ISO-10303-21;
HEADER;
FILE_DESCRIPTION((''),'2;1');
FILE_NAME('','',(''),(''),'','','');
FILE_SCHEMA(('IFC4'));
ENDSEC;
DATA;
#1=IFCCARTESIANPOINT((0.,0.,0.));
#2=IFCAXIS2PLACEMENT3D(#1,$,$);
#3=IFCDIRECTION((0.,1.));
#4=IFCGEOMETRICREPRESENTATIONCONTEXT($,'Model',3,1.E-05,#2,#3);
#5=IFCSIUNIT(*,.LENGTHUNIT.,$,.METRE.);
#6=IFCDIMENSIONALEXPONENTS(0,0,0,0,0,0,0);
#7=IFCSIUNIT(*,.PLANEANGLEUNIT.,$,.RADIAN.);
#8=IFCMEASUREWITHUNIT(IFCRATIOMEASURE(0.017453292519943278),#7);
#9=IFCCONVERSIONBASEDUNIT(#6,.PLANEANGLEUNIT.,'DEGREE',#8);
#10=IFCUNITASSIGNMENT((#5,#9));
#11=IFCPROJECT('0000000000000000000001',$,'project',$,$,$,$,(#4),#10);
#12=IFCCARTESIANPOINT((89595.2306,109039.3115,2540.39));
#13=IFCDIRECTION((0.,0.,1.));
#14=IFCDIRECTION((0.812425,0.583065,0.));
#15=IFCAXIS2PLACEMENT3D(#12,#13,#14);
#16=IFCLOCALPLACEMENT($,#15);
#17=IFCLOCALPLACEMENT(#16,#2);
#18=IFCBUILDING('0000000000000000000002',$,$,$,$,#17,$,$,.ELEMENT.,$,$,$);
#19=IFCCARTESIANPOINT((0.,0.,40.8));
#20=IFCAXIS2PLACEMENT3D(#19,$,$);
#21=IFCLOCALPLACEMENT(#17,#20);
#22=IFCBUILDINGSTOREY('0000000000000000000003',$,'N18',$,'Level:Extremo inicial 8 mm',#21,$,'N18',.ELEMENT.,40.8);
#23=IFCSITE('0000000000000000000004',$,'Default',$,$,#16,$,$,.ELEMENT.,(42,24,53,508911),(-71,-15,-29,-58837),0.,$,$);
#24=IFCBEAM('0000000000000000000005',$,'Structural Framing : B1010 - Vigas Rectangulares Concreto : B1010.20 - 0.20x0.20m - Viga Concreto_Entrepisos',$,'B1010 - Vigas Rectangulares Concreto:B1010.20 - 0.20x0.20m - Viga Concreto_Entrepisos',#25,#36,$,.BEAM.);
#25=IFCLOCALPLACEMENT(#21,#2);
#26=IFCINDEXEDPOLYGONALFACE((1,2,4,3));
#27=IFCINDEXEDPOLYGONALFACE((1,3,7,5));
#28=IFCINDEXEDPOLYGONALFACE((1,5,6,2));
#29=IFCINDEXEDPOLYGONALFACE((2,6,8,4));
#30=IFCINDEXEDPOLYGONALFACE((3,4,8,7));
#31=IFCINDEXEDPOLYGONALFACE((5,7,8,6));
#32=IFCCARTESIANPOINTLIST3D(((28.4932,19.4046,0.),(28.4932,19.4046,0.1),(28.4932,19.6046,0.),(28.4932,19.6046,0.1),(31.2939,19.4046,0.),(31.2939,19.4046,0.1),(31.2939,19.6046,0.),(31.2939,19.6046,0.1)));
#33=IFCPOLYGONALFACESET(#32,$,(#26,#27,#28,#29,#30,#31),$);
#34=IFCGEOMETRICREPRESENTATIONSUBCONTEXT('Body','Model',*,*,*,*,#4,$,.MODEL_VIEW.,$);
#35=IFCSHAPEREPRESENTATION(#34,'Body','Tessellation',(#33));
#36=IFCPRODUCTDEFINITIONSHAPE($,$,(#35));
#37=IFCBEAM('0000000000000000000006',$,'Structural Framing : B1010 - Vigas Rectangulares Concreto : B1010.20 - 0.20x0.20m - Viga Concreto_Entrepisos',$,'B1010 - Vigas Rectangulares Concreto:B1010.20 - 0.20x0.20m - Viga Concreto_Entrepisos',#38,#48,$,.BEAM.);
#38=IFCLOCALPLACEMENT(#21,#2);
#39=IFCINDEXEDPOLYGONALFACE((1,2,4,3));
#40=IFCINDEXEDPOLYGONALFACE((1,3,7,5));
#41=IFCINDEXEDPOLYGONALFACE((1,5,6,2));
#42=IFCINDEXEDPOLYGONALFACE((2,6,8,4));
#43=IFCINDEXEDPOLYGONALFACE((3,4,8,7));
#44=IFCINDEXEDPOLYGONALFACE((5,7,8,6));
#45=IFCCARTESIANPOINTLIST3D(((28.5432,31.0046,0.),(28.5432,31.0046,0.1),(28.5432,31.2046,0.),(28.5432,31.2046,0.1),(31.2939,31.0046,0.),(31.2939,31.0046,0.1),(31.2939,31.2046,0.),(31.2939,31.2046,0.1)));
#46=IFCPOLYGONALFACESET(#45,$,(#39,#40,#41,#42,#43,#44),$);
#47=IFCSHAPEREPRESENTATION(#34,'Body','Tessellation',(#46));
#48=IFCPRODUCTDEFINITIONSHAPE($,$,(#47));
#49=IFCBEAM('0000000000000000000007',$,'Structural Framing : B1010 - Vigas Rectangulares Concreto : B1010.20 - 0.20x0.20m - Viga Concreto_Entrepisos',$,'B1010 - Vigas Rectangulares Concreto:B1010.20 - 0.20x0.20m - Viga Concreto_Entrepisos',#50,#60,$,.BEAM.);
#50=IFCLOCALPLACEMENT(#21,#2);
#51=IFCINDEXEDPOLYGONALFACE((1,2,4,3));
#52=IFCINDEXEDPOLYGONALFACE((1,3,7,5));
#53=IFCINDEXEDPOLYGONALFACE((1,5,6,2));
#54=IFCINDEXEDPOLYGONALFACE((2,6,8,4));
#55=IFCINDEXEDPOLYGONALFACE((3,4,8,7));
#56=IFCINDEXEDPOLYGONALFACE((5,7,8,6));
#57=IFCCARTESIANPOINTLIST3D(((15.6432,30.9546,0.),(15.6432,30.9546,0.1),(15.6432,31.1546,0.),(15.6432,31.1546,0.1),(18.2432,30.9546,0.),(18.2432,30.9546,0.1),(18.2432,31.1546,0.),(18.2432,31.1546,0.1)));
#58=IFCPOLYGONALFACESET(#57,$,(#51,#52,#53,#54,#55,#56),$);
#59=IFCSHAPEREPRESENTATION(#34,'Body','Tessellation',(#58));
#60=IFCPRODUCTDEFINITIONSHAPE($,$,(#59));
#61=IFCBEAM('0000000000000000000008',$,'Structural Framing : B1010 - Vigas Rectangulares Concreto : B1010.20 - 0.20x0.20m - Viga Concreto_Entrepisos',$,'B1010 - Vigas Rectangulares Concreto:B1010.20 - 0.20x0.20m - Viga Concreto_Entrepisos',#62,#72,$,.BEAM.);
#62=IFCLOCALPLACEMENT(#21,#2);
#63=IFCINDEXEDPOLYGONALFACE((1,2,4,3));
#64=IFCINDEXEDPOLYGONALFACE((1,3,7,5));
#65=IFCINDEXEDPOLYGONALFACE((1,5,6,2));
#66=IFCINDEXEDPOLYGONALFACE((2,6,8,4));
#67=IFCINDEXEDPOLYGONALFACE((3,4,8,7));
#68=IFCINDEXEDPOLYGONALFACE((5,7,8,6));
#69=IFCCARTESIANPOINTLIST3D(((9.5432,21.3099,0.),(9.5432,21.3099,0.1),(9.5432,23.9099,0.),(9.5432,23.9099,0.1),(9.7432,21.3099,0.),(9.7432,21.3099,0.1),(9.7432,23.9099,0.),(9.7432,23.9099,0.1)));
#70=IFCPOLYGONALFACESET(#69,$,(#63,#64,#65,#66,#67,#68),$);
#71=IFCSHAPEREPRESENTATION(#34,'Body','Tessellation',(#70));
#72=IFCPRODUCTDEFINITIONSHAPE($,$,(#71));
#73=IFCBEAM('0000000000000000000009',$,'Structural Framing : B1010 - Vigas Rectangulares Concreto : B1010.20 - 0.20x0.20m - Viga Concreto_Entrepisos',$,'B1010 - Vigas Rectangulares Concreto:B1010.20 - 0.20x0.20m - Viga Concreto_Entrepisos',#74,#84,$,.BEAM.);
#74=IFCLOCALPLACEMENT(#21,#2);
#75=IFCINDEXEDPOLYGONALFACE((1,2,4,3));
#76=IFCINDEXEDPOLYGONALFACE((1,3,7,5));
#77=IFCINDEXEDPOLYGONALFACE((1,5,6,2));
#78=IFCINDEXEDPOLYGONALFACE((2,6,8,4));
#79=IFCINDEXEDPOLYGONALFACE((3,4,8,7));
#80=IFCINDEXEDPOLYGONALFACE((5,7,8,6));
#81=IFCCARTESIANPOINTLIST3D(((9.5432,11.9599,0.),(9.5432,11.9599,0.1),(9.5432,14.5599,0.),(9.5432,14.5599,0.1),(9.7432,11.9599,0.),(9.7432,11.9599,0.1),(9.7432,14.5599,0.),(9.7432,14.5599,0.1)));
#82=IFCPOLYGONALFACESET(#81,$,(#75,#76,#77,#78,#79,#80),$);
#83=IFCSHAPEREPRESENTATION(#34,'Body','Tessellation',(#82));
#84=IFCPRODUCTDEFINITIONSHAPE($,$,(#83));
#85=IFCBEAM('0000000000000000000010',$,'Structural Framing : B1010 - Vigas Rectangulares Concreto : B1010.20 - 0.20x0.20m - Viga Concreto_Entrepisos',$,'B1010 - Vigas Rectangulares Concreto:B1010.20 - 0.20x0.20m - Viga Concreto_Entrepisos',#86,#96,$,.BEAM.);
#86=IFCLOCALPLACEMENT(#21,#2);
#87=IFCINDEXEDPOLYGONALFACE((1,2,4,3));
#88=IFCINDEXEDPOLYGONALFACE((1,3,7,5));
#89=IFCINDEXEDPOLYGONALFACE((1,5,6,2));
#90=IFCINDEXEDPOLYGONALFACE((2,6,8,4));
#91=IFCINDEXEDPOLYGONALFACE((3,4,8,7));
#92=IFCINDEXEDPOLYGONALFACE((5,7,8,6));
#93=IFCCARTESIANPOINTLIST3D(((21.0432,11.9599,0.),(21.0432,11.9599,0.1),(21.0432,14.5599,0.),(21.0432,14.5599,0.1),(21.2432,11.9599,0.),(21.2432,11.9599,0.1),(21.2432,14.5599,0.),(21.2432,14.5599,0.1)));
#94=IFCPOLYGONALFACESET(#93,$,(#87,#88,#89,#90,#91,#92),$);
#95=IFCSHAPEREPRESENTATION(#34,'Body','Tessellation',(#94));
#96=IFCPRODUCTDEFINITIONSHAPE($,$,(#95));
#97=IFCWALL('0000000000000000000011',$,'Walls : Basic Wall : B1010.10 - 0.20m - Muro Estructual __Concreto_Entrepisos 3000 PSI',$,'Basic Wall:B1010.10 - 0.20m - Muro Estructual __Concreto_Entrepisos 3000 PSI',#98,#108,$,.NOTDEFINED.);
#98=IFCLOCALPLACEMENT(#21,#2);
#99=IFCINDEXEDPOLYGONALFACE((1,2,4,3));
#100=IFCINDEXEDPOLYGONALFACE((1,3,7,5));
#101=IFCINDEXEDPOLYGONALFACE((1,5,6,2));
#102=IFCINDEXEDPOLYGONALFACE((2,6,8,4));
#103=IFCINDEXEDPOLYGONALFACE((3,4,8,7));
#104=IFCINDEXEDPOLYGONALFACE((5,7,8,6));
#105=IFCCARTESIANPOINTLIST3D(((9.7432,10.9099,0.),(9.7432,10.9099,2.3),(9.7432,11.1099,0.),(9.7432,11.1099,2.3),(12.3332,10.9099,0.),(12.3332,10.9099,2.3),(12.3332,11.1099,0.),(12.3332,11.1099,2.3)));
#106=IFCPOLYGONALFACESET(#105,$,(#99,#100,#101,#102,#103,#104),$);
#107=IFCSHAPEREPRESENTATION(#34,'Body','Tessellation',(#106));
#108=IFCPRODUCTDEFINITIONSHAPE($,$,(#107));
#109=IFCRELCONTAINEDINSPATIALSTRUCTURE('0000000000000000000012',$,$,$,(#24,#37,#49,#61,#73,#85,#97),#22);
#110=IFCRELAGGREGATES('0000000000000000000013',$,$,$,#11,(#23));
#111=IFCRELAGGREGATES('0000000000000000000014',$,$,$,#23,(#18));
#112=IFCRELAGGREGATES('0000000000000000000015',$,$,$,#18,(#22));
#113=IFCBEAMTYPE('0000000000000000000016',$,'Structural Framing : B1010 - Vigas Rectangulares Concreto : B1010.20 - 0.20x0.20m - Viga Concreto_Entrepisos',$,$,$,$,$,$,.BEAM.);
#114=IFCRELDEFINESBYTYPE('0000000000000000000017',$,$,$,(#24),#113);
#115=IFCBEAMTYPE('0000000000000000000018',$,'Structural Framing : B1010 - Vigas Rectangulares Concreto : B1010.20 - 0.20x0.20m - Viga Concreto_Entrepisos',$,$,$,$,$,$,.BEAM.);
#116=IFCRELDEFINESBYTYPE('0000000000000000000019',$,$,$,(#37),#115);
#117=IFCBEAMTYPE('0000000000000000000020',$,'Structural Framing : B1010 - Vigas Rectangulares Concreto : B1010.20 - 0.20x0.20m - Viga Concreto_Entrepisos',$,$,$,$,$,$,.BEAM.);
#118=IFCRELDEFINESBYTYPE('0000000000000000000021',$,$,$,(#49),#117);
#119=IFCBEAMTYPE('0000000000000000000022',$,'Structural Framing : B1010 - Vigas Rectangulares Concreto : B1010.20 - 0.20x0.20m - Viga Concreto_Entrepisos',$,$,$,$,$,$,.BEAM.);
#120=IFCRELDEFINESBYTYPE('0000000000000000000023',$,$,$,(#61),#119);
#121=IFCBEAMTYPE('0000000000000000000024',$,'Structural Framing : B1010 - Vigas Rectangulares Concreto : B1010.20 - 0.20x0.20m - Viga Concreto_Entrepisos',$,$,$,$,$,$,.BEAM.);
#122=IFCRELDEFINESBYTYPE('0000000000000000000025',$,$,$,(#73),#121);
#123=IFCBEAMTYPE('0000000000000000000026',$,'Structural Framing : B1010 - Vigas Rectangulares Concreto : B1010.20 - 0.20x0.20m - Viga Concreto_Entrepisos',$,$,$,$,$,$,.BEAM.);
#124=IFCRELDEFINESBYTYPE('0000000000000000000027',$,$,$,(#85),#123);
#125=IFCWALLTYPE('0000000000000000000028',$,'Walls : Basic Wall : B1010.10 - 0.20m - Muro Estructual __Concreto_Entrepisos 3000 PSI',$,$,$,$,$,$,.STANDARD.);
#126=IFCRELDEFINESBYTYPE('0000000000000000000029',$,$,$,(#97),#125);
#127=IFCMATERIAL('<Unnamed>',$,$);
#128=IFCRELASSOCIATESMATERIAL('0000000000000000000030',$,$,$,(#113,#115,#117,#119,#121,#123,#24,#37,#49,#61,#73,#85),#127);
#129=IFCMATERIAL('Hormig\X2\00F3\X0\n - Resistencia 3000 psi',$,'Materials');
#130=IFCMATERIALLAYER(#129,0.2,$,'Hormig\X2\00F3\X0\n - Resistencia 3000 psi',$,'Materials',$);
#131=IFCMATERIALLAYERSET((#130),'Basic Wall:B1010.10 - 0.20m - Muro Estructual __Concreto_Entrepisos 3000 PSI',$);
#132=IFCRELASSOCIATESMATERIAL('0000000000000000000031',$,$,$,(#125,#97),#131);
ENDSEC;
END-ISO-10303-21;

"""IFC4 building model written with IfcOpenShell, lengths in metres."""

from ifc_helpers import new_model, entity, si_unit, converted_unit, direction, frame, frame_2d, origin, place, context, subcontext, project, spatial, polyline, segment, composite_curve, rectangle, outline, extrude, source, transform, mapped, material, layer, layer_set, layer_usage, material_profile, profile_set, profile_usage, type_object, type_shapes, element, save


model = new_model("IFC4")

# Units and contexts
model_context = context("Model", 3, precision=1e-05, world=origin(), true_north=direction((0.0, 1.0)))
body_context = subcontext(model_context, "Body", "Model", "MODEL_VIEW")
ifc_project = project(units=[si_unit("LENGTHUNIT", "METRE"), converted_unit("PLANEANGLEUNIT", "DEGREE", entity("IfcRatioMeasure", 0.017453292519943278), si_unit("PLANEANGLEUNIT", "RADIAN"), dimensions=[0, 0, 0, 0, 0, 0, 0])], contexts=[model_context])

# Site, building, storey
site_placement = place(None, frame((89595.2306, 109039.3115, 2540.39), z_axis=(0.0, 0.0, 1.0), x_axis=(0.812425, 0.583065, 0.0)))
site = spatial("IfcSite", under=ifc_project, at=site_placement, Name="Default", CompositionType="ELEMENT", RefLatitude=(42, 24, 53, 508911), RefLongitude=(-71, -15, -29, -58837), RefElevation=0.0)
building_placement = place(site_placement, origin())
building = spatial("IfcBuilding", under=site, at=building_placement, CompositionType="ELEMENT")
storey_placement = place(building_placement, frame((0.0, 0.0, 40.8)))
storey = spatial("IfcBuildingStorey", under=building, at=storey_placement, Name="N18", ObjectType="Level:Extremo inicial 8 mm", LongName="N18", CompositionType="ELEMENT", Elevation=40.8)

# Beams
ifc_material_1 = material(Name="<Unnamed>")
ifc_material_profile_1 = material_profile(ifc_material_1, outline(composite_curve([segment(polyline([(-0.1, 0.0, 0.0), (-0.1, 0.1, 0.0)]), True, "CONTINUOUS"), segment(polyline([(-0.1, 0.1, 0.0), (0.1, 0.1, 0.0)]), True, "CONTINUOUS"), segment(polyline([(0.1, 0.1, 0.0), (0.1, 0.0, 0.0)]), True, "CONTINUOUS"), segment(polyline([(0.1, 0.0, 0.0), (-0.1, 0.0, 0.0)]), True, "CONTINUOUS")], self_intersect=False), kind="CURVE"), Name="B1010.20 - 0.20x0.20m - Viga Concreto_Entrepisos")
ifc_material_profile_2 = material_profile(ifc_material_1, outline(composite_curve([segment(polyline([(-1.4004, -0.1, 0.1), (-1.4004, 0.1, 0.1)]), True, "CONTINUOUS"), segment(polyline([(-1.4004, 0.1, 0.1), (-1.4004, 0.1, -0.1)]), True, "CONTINUOUS"), segment(polyline([(-1.4004, 0.1, -0.1), (-1.4004, -0.1, -0.1)]), True, "CONTINUOUS"), segment(polyline([(-1.4004, -0.1, -0.1), (-1.4004, -0.1, 0.1)]), True, "CONTINUOUS")], self_intersect=False), kind="CURVE"), Name="B1010.20 - 0.20x0.20m - Viga Concreto_Entrepisos")
ifc_profile_set_1 = profile_set([ifc_material_profile_1, ifc_material_profile_2], Name="B1010.20 - 0.20x0.20m - Viga Concreto_Entrepisos")
ifc_profile_usage_1 = profile_usage(ifc_profile_set_1, cardinal=8)
beam_type_1 = type_object("IfcBeamType", Name="Structural Framing : B1010 - Vigas Rectangulares Concreto : B1010.20 - 0.20x0.20m - Viga Concreto_Entrepisos", PredefinedType="BEAM", material=ifc_profile_set_1)
shared_shape_1 = source(origin(), body_context, "Body", "SweptSolid", [
    extrude(rectangle(XDim=0.1, YDim=0.2, at=frame_2d((0.0, 0.0), x_axis=(1.0, 0.0))), frame((31.2939, 19.5046, 40.85), z_axis=(-1.0, 0.0, 0.0), x_axis=(0.0, 0.0, -1.0)), (0.0, 0.0, 1.0), 2.8007),
])
type_shapes(beam_type_1, [shared_shape_1])
beam_1_placement = place(storey_placement, frame((0.0, 0.0, -40.8)))
element("IfcBeam", 1, at=beam_1_placement, inside=storey, type_object=beam_type_1, material=ifc_profile_usage_1, Name="Structural Framing : B1010 - Vigas Rectangulares Concreto : B1010.20 - 0.20x0.20m - Viga Concreto_Entrepisos", ObjectType="B1010 - Vigas Rectangulares Concreto:B1010.20 - 0.20x0.20m - Viga Concreto_Entrepisos", PredefinedType="BEAM", context=body_context, shape_type="MappedRepresentation", body=[
    mapped(shared_shape_1, transform((0.0, 0.0, 0.0), scale=1.0)),
])
ifc_profile_usage_2 = profile_usage(ifc_profile_set_1, cardinal=8)
beam_type_2 = type_object("IfcBeamType", Name="Structural Framing : B1010 - Vigas Rectangulares Concreto : B1010.20 - 0.20x0.20m - Viga Concreto_Entrepisos", PredefinedType="BEAM", material=ifc_profile_set_1)
shared_shape_2 = source(origin(), body_context, "Body", "SweptSolid", [
    extrude(rectangle(XDim=0.1, YDim=0.2, at=frame_2d((0.0, 0.0), x_axis=(1.0, 0.0))), frame((31.2939, 31.1046, 40.85), z_axis=(-1.0, 0.0, 0.0), x_axis=(0.0, 0.0, -1.0)), (0.0, 0.0, 1.0), 2.7507),
])
type_shapes(beam_type_2, [shared_shape_2])
beam_2_placement = place(storey_placement, frame((0.0, 0.0, -40.8)))
element("IfcBeam", 2, at=beam_2_placement, inside=storey, type_object=beam_type_2, material=ifc_profile_usage_2, Name="Structural Framing : B1010 - Vigas Rectangulares Concreto : B1010.20 - 0.20x0.20m - Viga Concreto_Entrepisos", ObjectType="B1010 - Vigas Rectangulares Concreto:B1010.20 - 0.20x0.20m - Viga Concreto_Entrepisos", PredefinedType="BEAM", context=body_context, shape_type="MappedRepresentation", body=[
    mapped(shared_shape_2, transform((0.0, 0.0, 0.0), scale=1.0)),
])
ifc_profile_usage_3 = profile_usage(ifc_profile_set_1, cardinal=8)
beam_type_3 = type_object("IfcBeamType", Name="Structural Framing : B1010 - Vigas Rectangulares Concreto : B1010.20 - 0.20x0.20m - Viga Concreto_Entrepisos", PredefinedType="BEAM", material=ifc_profile_set_1)
shared_shape_3 = source(origin(), body_context, "Body", "SweptSolid", [
    extrude(rectangle(XDim=0.1, YDim=0.2, at=frame_2d((0.0, 0.0), x_axis=(1.0, 0.0))), frame((18.2432, 31.0546, 40.85), z_axis=(-1.0, 0.0, 0.0), x_axis=(0.0, 0.0, -1.0)), (0.0, 0.0, 1.0), 2.6),
])
type_shapes(beam_type_3, [shared_shape_3])
beam_3_placement = place(storey_placement, frame((0.0, 0.0, -40.8)))
element("IfcBeam", 3, at=beam_3_placement, inside=storey, type_object=beam_type_3, material=ifc_profile_usage_3, Name="Structural Framing : B1010 - Vigas Rectangulares Concreto : B1010.20 - 0.20x0.20m - Viga Concreto_Entrepisos", ObjectType="B1010 - Vigas Rectangulares Concreto:B1010.20 - 0.20x0.20m - Viga Concreto_Entrepisos", PredefinedType="BEAM", context=body_context, shape_type="MappedRepresentation", body=[
    mapped(shared_shape_3, transform((0.0, 0.0, 0.0), scale=1.0)),
])
ifc_profile_usage_4 = profile_usage(ifc_profile_set_1, cardinal=8)
beam_type_4 = type_object("IfcBeamType", Name="Structural Framing : B1010 - Vigas Rectangulares Concreto : B1010.20 - 0.20x0.20m - Viga Concreto_Entrepisos", PredefinedType="BEAM", material=ifc_profile_set_1)
shared_shape_4 = source(origin(), body_context, "Body", "SweptSolid", [
    extrude(rectangle(XDim=0.1, YDim=0.2, at=frame_2d((0.0, 0.0), x_axis=(0.0, 1.0))), frame((9.6432, 21.3099, 40.85), z_axis=(0.0, 1.0, 0.0), x_axis=(-1.0, 0.0, 0.0)), (0.0, 0.0, 1.0), 2.6),
])
type_shapes(beam_type_4, [shared_shape_4])
beam_4_placement = place(storey_placement, frame((0.0, 0.0, -40.8)))
element("IfcBeam", 4, at=beam_4_placement, inside=storey, type_object=beam_type_4, material=ifc_profile_usage_4, Name="Structural Framing : B1010 - Vigas Rectangulares Concreto : B1010.20 - 0.20x0.20m - Viga Concreto_Entrepisos", ObjectType="B1010 - Vigas Rectangulares Concreto:B1010.20 - 0.20x0.20m - Viga Concreto_Entrepisos", PredefinedType="BEAM", context=body_context, shape_type="MappedRepresentation", body=[
    mapped(shared_shape_4, transform((0.0, 0.0, 0.0), scale=1.0)),
])
ifc_profile_usage_5 = profile_usage(ifc_profile_set_1, cardinal=8)
beam_type_5 = type_object("IfcBeamType", Name="Structural Framing : B1010 - Vigas Rectangulares Concreto : B1010.20 - 0.20x0.20m - Viga Concreto_Entrepisos", PredefinedType="BEAM", material=ifc_profile_set_1)
shared_shape_5 = source(origin(), body_context, "Body", "SweptSolid", [
    extrude(rectangle(XDim=0.1, YDim=0.2, at=frame_2d((0.0, 0.0), x_axis=(0.0, 1.0))), frame((9.6432, 11.9599, 40.85), z_axis=(0.0, 1.0, 0.0), x_axis=(-1.0, 0.0, 0.0)), (0.0, 0.0, 1.0), 2.6),
])
type_shapes(beam_type_5, [shared_shape_5])
beam_5_placement = place(storey_placement, frame((0.0, 0.0, -40.8)))
element("IfcBeam", 5, at=beam_5_placement, inside=storey, type_object=beam_type_5, material=ifc_profile_usage_5, Name="Structural Framing : B1010 - Vigas Rectangulares Concreto : B1010.20 - 0.20x0.20m - Viga Concreto_Entrepisos", ObjectType="B1010 - Vigas Rectangulares Concreto:B1010.20 - 0.20x0.20m - Viga Concreto_Entrepisos", PredefinedType="BEAM", context=body_context, shape_type="MappedRepresentation", body=[
    mapped(shared_shape_5, transform((0.0, 0.0, 0.0), scale=1.0)),
])
ifc_profile_usage_6 = profile_usage(ifc_profile_set_1, cardinal=8)
beam_type_6 = type_object("IfcBeamType", Name="Structural Framing : B1010 - Vigas Rectangulares Concreto : B1010.20 - 0.20x0.20m - Viga Concreto_Entrepisos", PredefinedType="BEAM", material=ifc_profile_set_1)
shared_shape_6 = source(origin(), body_context, "Body", "SweptSolid", [
    extrude(rectangle(XDim=0.1, YDim=0.2, at=frame_2d((0.0, 0.0), x_axis=(0.0, 1.0))), frame((21.1432, 11.9599, 40.85), z_axis=(0.0, 1.0, 0.0), x_axis=(-1.0, 0.0, 0.0)), (0.0, 0.0, 1.0), 2.6),
])
type_shapes(beam_type_6, [shared_shape_6])
beam_6_placement = place(storey_placement, frame((0.0, 0.0, -40.8)))
element("IfcBeam", 6, at=beam_6_placement, inside=storey, type_object=beam_type_6, material=ifc_profile_usage_6, Name="Structural Framing : B1010 - Vigas Rectangulares Concreto : B1010.20 - 0.20x0.20m - Viga Concreto_Entrepisos", ObjectType="B1010 - Vigas Rectangulares Concreto:B1010.20 - 0.20x0.20m - Viga Concreto_Entrepisos", PredefinedType="BEAM", context=body_context, shape_type="MappedRepresentation", body=[
    mapped(shared_shape_6, transform((0.0, 0.0, 0.0), scale=1.0)),
])

# Wall
ifc_material_2 = material(Name="Hormigón - Resistencia 3000 psi", Category="Materials")
ifc_layer_1 = layer(ifc_material_2, 0.2, Name="Hormigón - Resistencia 3000 psi", Category="Materials")
ifc_layer_set_1 = layer_set([ifc_layer_1], Name="Basic Wall:B1010.10 - 0.20m - Muro Estructual __Concreto_Entrepisos 3000 PSI")
ifc_layer_usage_1 = layer_usage(ifc_layer_set_1, "AXIS2", "POSITIVE", -0.1)
wall_type = type_object("IfcWallType", Name="Walls : Basic Wall : B1010.10 - 0.20m - Muro Estructual __Concreto_Entrepisos 3000 PSI", PredefinedType="STANDARD", material=ifc_layer_set_1)
wall_placement = place(storey_placement, frame((9.7432, 11.0099, 0.0)))
element("IfcWall", 7, at=wall_placement, inside=storey, type_object=wall_type, material=ifc_layer_usage_1, Name="Walls : Basic Wall : B1010.10 - 0.20m - Muro Estructual __Concreto_Entrepisos 3000 PSI", ObjectType="Basic Wall:B1010.10 - 0.20m - Muro Estructual __Concreto_Entrepisos 3000 PSI", PredefinedType="NOTDEFINED", context=body_context, shape_type="SweptSolid", body=[
    extrude(rectangle(XDim=2.59, YDim=0.2, at=frame_2d((1.295, 0.0), x_axis=(-1.0, 0.0))), origin(), (0.0, 0.0, 1.0), 2.3),
])

save(model, "model.ifc")
